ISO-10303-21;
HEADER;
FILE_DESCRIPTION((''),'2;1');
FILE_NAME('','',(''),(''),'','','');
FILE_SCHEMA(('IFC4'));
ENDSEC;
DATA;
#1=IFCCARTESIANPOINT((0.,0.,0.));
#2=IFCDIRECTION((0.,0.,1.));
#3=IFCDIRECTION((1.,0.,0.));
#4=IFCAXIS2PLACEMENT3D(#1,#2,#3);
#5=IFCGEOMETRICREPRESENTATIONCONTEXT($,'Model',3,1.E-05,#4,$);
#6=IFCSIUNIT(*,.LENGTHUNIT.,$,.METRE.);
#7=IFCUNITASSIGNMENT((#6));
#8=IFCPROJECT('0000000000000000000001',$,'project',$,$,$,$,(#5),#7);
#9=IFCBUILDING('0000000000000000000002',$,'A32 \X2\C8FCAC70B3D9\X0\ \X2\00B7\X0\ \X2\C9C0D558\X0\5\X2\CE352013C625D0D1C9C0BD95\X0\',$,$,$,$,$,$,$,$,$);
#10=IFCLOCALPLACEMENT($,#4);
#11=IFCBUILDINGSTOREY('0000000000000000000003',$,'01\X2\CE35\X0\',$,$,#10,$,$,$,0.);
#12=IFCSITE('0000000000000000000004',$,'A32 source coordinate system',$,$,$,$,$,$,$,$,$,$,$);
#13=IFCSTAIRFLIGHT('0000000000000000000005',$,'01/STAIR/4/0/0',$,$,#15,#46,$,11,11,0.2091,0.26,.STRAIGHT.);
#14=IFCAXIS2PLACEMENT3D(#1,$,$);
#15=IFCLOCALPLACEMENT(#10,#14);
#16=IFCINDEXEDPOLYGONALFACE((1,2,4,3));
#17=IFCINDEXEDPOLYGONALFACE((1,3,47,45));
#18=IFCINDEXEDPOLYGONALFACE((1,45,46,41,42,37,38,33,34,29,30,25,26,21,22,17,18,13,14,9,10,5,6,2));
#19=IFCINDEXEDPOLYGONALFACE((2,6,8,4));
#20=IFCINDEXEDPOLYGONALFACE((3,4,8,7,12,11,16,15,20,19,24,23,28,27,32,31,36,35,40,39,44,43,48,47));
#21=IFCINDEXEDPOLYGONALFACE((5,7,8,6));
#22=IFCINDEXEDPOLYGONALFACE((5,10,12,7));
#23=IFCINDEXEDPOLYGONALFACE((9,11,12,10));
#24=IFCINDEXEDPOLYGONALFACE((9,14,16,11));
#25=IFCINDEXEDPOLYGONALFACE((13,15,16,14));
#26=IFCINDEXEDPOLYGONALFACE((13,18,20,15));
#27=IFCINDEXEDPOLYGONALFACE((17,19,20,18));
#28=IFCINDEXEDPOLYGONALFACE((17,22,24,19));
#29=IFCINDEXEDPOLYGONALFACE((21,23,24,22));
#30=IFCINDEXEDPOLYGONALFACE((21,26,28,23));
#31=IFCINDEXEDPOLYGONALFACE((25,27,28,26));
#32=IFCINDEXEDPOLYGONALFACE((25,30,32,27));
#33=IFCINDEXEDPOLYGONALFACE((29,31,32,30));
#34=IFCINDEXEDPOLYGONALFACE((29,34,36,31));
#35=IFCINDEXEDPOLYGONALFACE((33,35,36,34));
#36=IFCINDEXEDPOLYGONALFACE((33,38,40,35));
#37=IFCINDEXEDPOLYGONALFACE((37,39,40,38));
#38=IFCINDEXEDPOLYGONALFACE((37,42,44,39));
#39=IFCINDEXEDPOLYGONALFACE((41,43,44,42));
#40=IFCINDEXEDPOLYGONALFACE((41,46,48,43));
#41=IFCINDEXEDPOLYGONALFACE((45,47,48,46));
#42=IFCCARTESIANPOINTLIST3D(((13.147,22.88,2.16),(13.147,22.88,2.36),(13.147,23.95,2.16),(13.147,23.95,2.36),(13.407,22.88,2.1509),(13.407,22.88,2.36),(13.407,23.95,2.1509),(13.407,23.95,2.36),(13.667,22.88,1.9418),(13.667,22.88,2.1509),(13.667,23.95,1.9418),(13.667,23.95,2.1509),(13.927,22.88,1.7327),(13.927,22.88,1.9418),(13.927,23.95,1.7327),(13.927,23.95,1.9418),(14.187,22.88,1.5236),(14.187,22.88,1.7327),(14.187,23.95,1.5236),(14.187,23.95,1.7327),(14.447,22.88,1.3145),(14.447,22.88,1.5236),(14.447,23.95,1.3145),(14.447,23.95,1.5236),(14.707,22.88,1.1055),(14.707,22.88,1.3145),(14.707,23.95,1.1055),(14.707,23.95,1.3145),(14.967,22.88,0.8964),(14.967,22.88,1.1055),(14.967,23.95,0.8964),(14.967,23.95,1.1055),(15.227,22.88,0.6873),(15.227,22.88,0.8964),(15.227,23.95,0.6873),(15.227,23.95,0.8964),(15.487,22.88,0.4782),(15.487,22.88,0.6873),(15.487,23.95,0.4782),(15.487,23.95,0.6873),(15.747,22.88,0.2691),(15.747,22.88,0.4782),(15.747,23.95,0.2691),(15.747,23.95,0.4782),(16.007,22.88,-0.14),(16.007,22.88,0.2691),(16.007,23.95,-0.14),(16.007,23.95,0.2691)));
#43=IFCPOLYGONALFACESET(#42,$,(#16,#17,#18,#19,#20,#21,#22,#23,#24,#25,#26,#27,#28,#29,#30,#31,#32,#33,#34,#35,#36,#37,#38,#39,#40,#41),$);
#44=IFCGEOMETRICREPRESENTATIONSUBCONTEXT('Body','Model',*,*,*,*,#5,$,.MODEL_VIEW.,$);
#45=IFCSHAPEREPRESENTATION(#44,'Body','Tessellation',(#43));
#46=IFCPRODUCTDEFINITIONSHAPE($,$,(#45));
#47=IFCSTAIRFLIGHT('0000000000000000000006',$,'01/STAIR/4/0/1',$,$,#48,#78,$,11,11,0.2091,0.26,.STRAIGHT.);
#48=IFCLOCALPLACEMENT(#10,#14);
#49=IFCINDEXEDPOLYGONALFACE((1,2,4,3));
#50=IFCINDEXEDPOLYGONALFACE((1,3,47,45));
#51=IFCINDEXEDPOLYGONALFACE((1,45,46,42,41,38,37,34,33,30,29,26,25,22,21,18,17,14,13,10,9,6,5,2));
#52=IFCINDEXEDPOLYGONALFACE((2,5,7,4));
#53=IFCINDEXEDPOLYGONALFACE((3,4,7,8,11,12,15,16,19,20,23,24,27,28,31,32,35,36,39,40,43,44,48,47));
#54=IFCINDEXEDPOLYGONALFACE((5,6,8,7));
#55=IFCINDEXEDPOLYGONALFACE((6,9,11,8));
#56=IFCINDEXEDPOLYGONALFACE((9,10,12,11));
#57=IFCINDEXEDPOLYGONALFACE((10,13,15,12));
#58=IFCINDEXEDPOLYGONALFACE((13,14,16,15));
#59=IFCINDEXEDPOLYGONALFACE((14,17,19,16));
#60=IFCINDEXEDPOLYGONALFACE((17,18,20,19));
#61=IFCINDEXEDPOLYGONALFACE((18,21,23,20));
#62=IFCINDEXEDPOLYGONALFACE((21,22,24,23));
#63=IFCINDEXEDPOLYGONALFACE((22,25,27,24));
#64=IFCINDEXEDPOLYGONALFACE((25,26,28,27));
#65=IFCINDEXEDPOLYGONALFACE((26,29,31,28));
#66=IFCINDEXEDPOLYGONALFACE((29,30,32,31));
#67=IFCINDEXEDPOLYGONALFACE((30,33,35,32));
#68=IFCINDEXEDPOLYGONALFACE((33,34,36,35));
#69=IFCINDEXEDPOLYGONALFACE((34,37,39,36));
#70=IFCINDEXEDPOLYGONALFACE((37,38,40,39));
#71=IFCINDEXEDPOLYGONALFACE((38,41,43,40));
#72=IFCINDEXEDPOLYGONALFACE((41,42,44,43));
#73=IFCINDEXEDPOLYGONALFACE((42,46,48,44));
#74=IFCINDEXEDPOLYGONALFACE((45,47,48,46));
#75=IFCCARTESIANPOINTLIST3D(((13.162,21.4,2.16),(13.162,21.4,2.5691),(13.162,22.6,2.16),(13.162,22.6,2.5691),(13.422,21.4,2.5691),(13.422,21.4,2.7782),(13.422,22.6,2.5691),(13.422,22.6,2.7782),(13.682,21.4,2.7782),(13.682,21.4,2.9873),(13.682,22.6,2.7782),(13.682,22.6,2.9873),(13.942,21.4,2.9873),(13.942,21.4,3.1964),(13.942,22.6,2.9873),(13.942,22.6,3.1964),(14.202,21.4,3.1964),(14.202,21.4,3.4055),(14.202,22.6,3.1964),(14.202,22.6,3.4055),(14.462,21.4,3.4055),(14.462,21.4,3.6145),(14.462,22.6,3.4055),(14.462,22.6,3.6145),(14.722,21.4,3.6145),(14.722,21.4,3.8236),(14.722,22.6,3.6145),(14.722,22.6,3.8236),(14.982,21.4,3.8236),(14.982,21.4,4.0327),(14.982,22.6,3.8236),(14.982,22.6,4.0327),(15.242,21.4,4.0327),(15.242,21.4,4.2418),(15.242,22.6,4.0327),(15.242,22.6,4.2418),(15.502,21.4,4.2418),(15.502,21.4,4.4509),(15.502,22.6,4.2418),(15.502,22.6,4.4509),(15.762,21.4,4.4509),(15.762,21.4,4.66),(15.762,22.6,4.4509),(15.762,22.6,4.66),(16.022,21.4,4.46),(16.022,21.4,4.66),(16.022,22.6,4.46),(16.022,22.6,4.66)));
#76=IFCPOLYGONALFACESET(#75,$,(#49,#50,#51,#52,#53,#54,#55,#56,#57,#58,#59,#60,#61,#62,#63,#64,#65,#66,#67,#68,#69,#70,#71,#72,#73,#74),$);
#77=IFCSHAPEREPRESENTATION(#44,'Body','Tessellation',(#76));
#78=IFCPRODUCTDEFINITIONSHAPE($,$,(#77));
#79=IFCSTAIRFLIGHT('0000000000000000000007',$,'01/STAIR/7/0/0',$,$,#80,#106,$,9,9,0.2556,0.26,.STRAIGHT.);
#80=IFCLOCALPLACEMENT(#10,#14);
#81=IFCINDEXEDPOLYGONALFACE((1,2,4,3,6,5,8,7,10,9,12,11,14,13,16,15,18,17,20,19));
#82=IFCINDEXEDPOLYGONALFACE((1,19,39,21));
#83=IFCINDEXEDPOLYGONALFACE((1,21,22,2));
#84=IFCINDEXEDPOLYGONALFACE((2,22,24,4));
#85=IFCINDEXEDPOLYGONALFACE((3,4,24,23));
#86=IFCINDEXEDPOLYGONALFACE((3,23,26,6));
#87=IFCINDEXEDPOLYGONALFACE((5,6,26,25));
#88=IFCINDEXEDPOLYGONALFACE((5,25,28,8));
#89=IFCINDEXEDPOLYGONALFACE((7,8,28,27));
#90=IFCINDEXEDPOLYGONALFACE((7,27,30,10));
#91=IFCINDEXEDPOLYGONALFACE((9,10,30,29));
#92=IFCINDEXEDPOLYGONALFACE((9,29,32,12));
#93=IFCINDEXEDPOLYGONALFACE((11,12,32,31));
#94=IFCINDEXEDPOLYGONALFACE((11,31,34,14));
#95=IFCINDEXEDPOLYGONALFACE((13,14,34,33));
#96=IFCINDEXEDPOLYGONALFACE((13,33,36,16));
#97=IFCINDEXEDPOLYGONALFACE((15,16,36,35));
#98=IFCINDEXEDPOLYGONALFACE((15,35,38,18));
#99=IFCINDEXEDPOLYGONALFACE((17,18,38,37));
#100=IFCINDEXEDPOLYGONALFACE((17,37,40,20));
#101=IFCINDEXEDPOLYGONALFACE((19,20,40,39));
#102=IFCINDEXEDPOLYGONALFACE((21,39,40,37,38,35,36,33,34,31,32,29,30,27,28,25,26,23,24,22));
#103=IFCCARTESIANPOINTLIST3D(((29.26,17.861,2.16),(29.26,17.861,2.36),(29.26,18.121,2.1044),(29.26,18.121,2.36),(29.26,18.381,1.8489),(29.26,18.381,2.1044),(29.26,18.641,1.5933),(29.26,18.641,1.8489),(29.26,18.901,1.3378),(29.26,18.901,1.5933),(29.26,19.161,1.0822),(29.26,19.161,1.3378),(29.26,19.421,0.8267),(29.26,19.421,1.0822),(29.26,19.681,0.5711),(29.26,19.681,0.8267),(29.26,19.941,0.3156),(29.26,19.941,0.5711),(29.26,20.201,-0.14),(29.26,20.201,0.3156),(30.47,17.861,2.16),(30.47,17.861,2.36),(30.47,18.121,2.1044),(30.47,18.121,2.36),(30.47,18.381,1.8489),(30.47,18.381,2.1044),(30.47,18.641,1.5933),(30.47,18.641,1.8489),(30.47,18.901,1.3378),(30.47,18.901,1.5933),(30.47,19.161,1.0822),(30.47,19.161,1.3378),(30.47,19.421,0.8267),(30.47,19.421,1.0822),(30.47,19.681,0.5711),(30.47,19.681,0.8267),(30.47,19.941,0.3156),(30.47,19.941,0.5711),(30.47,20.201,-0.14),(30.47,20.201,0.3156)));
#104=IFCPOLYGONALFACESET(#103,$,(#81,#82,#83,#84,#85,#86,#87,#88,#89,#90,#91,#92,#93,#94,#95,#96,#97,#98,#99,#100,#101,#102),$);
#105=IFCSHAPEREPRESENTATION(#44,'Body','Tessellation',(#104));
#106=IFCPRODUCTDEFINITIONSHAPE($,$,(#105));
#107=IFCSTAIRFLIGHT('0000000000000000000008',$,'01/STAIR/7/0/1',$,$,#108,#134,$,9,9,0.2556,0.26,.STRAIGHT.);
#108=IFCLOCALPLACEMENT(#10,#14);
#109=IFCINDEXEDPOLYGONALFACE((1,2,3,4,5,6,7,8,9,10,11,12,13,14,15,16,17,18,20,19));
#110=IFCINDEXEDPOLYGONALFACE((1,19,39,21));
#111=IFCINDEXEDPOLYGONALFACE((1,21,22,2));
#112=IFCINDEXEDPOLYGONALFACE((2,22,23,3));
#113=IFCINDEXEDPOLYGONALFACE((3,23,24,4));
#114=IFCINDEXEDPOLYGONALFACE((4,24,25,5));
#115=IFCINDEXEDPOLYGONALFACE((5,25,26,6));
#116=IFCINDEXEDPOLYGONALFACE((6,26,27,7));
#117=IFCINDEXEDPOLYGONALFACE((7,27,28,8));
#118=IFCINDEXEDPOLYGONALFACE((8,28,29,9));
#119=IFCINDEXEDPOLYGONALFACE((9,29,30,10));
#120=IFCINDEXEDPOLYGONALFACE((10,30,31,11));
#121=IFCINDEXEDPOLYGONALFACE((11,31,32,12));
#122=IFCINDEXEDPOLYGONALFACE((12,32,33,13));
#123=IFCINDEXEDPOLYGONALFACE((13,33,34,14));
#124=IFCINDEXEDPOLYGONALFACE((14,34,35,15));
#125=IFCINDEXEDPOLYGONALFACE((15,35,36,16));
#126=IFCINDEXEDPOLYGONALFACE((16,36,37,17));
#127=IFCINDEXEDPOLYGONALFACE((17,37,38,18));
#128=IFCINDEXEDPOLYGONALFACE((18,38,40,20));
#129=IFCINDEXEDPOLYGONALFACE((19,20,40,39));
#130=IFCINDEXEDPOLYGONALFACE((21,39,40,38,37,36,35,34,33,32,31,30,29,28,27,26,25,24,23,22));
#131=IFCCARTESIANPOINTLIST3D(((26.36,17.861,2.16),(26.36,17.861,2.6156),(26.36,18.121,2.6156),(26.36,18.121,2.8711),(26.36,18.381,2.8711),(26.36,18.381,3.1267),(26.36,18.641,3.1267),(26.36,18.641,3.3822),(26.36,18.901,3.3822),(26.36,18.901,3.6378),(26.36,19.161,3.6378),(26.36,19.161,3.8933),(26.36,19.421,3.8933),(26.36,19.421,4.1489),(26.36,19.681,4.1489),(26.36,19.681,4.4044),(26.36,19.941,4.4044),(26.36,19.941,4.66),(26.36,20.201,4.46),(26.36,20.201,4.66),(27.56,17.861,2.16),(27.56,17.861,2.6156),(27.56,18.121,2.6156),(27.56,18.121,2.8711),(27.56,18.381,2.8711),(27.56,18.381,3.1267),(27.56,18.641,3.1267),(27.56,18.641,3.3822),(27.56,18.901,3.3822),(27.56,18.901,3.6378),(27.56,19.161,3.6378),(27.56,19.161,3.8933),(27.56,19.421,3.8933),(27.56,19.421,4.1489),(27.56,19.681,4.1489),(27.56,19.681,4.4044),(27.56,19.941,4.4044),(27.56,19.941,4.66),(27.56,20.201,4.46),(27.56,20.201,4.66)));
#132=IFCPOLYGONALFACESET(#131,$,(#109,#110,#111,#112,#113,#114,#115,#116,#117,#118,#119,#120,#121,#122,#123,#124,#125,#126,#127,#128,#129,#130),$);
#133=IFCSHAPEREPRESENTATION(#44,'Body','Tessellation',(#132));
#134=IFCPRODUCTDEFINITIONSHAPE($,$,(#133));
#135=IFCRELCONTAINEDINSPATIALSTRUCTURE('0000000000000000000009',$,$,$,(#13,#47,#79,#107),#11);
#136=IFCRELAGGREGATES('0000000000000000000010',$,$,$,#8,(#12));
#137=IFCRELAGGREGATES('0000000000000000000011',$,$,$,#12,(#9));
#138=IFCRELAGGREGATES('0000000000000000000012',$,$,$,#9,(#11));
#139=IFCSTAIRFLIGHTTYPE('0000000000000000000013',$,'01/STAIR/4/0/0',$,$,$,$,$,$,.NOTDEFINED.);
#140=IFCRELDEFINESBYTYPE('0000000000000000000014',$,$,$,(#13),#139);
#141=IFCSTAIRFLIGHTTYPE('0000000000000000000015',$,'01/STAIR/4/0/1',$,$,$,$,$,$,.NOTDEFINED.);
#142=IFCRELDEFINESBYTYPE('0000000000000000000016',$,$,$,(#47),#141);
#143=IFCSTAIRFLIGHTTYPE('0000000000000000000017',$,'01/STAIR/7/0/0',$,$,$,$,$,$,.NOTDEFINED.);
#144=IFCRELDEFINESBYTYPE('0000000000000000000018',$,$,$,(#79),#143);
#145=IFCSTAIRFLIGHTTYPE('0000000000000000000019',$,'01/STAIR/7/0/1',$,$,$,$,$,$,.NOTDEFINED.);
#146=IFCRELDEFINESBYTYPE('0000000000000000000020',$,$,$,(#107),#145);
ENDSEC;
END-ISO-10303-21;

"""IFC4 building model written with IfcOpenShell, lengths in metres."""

from ifc_helpers import new_model, si_unit, frame, origin, origin_with_axes, place, context, subcontext, project, spatial, polyline, outline, extrude, source, transform, mapped, type_object, type_shapes, element, save


model = new_model("IFC4")

# Units and contexts
model_context = context("Model", 3, precision=1e-05, world=origin_with_axes())
body_context = subcontext(model_context, "Body", "Model", "MODEL_VIEW")
ifc_project = project(units=[si_unit("LENGTHUNIT", "METRE")], contexts=[model_context])

# Site, building, storey
storey_placement = place(None, origin_with_axes())
site = spatial("IfcSite", under=ifc_project, Name="A32 source coordinate system")
building = spatial("IfcBuilding", under=site, Name="A32 주거동 · 지하5층–옥탑지붕")
storey = spatial("IfcBuildingStorey", under=building, at=storey_placement, Name="01층", Elevation=0.0)

# Stair flights
stair_flight_type_1 = type_object("IfcStairFlightType", Name="01/STAIR/4/0/0", PredefinedType="NOTDEFINED")
shared_shape_1 = source(origin(), body_context, "Body", "SweptSolid", [
    extrude(outline(polyline([(0.0, -0.14), (2.86, 2.16), (2.86, 2.36), (2.6, 2.36), (2.6, 2.1509), (2.34, 2.1509), (2.34, 1.9418), (2.08, 1.9418), (2.08, 1.7327), (1.82, 1.7327), (1.82, 1.5236), (1.56, 1.5236), (1.56, 1.3145), (1.3, 1.3145), (1.3, 1.1055), (1.04, 1.1055), (1.04, 0.8964), (0.78, 0.8964), (0.78, 0.6873), (0.52, 0.6873), (0.52, 0.4782), (0.26, 0.4782), (0.26, 0.2691), (0.0, 0.2691), (0.0, -0.14)])), frame((16.007, 22.88, 0.0), z_axis=(0.0, 1.0, 0.0), x_axis=(-1.0, 0.0, 0.0)), (0.0, 0.0, 1.0), 1.07),
])
type_shapes(stair_flight_type_1, [shared_shape_1])
stair_flight_1_placement = place(storey_placement, origin_with_axes())
element("IfcStairFlight", 1, at=stair_flight_1_placement, inside=storey, type_object=stair_flight_type_1, Name="01/STAIR/4/0/0", NumberOfRisers=11, NumberOfTreads=11, PredefinedType="STRAIGHT", RiserHeight=0.2091, TreadLength=0.26, context=body_context, shape_type="MappedRepresentation", body=[
    mapped(shared_shape_1, transform((0.0, 0.0, 0.0), scale=1.0)),
])
stair_flight_type_2 = type_object("IfcStairFlightType", Name="01/STAIR/4/0/1", PredefinedType="NOTDEFINED")
shared_shape_2 = source(origin(), body_context, "Body", "SweptSolid", [
    extrude(outline(polyline([(0.0, 2.16), (2.86, 4.46), (2.86, 4.66), (2.6, 4.66), (2.6, 4.4509), (2.34, 4.4509), (2.34, 4.2418), (2.08, 4.2418), (2.08, 4.0327), (1.82, 4.0327), (1.82, 3.8236), (1.56, 3.8236), (1.56, 3.6145), (1.3, 3.6145), (1.3, 3.4055), (1.04, 3.4055), (1.04, 3.1964), (0.78, 3.1964), (0.78, 2.9873), (0.52, 2.9873), (0.52, 2.7782), (0.26, 2.7782), (0.26, 2.5691), (0.0, 2.5691), (0.0, 2.16)])), frame((13.162, 22.6, 0.0), z_axis=(0.0, -1.0, 0.0), x_axis=(1.0, 0.0, 0.0)), (0.0, 0.0, 1.0), 1.2),
])
type_shapes(stair_flight_type_2, [shared_shape_2])
stair_flight_2_placement = place(storey_placement, origin_with_axes())
element("IfcStairFlight", 2, at=stair_flight_2_placement, inside=storey, type_object=stair_flight_type_2, Name="01/STAIR/4/0/1", NumberOfRisers=11, NumberOfTreads=11, PredefinedType="STRAIGHT", RiserHeight=0.2091, TreadLength=0.26, context=body_context, shape_type="MappedRepresentation", body=[
    mapped(shared_shape_2, transform((0.0, 0.0, 0.0), scale=1.0)),
])
stair_flight_type_3 = type_object("IfcStairFlightType", Name="01/STAIR/7/0/0", PredefinedType="NOTDEFINED")
shared_shape_3 = source(origin(), body_context, "Body", "SweptSolid", [
    extrude(outline(polyline([(0.0, -0.14), (2.34, 2.16), (2.34, 2.36), (2.08, 2.36), (2.08, 2.1044), (1.82, 2.1044), (1.82, 1.8489), (1.56, 1.8489), (1.56, 1.5933), (1.3, 1.5933), (1.3, 1.3378), (1.04, 1.3378), (1.04, 1.0822), (0.78, 1.0822), (0.78, 0.8267), (0.52, 0.8267), (0.52, 0.5711), (0.26, 0.5711), (0.26, 0.3156), (0.0, 0.3156), (0.0, -0.14)])), frame((30.47, 20.201, 0.0), z_axis=(-1.0, 0.0, 0.0), x_axis=(0.0, -1.0, 0.0)), (0.0, 0.0, 1.0), 1.21),
])
type_shapes(stair_flight_type_3, [shared_shape_3])
stair_flight_3_placement = place(storey_placement, origin_with_axes())
element("IfcStairFlight", 3, at=stair_flight_3_placement, inside=storey, type_object=stair_flight_type_3, Name="01/STAIR/7/0/0", NumberOfRisers=9, NumberOfTreads=9, PredefinedType="STRAIGHT", RiserHeight=0.2556, TreadLength=0.26, context=body_context, shape_type="MappedRepresentation", body=[
    mapped(shared_shape_3, transform((0.0, 0.0, 0.0), scale=1.0)),
])
stair_flight_type_4 = type_object("IfcStairFlightType", Name="01/STAIR/7/0/1", PredefinedType="NOTDEFINED")
shared_shape_4 = source(origin(), body_context, "Body", "SweptSolid", [
    extrude(outline(polyline([(0.0, 2.16), (2.34, 4.46), (2.34, 4.66), (2.08, 4.66), (2.08, 4.4044), (1.82, 4.4044), (1.82, 4.1489), (1.56, 4.1489), (1.56, 3.8933), (1.3, 3.8933), (1.3, 3.6378), (1.04, 3.6378), (1.04, 3.3822), (0.78, 3.3822), (0.78, 3.1267), (0.52, 3.1267), (0.52, 2.8711), (0.26, 2.8711), (0.26, 2.6156), (0.0, 2.6156), (0.0, 2.16)])), frame((26.36, 17.861, 0.0), z_axis=(1.0, 0.0, 0.0), x_axis=(0.0, 1.0, 0.0)), (0.0, 0.0, 1.0), 1.2),
])
type_shapes(stair_flight_type_4, [shared_shape_4])
stair_flight_4_placement = place(storey_placement, origin_with_axes())
element("IfcStairFlight", 4, at=stair_flight_4_placement, inside=storey, type_object=stair_flight_type_4, Name="01/STAIR/7/0/1", NumberOfRisers=9, NumberOfTreads=9, PredefinedType="STRAIGHT", RiserHeight=0.2556, TreadLength=0.26, context=body_context, shape_type="MappedRepresentation", body=[
    mapped(shared_shape_4, transform((0.0, 0.0, 0.0), scale=1.0)),
])

save(model, "model.ifc")
